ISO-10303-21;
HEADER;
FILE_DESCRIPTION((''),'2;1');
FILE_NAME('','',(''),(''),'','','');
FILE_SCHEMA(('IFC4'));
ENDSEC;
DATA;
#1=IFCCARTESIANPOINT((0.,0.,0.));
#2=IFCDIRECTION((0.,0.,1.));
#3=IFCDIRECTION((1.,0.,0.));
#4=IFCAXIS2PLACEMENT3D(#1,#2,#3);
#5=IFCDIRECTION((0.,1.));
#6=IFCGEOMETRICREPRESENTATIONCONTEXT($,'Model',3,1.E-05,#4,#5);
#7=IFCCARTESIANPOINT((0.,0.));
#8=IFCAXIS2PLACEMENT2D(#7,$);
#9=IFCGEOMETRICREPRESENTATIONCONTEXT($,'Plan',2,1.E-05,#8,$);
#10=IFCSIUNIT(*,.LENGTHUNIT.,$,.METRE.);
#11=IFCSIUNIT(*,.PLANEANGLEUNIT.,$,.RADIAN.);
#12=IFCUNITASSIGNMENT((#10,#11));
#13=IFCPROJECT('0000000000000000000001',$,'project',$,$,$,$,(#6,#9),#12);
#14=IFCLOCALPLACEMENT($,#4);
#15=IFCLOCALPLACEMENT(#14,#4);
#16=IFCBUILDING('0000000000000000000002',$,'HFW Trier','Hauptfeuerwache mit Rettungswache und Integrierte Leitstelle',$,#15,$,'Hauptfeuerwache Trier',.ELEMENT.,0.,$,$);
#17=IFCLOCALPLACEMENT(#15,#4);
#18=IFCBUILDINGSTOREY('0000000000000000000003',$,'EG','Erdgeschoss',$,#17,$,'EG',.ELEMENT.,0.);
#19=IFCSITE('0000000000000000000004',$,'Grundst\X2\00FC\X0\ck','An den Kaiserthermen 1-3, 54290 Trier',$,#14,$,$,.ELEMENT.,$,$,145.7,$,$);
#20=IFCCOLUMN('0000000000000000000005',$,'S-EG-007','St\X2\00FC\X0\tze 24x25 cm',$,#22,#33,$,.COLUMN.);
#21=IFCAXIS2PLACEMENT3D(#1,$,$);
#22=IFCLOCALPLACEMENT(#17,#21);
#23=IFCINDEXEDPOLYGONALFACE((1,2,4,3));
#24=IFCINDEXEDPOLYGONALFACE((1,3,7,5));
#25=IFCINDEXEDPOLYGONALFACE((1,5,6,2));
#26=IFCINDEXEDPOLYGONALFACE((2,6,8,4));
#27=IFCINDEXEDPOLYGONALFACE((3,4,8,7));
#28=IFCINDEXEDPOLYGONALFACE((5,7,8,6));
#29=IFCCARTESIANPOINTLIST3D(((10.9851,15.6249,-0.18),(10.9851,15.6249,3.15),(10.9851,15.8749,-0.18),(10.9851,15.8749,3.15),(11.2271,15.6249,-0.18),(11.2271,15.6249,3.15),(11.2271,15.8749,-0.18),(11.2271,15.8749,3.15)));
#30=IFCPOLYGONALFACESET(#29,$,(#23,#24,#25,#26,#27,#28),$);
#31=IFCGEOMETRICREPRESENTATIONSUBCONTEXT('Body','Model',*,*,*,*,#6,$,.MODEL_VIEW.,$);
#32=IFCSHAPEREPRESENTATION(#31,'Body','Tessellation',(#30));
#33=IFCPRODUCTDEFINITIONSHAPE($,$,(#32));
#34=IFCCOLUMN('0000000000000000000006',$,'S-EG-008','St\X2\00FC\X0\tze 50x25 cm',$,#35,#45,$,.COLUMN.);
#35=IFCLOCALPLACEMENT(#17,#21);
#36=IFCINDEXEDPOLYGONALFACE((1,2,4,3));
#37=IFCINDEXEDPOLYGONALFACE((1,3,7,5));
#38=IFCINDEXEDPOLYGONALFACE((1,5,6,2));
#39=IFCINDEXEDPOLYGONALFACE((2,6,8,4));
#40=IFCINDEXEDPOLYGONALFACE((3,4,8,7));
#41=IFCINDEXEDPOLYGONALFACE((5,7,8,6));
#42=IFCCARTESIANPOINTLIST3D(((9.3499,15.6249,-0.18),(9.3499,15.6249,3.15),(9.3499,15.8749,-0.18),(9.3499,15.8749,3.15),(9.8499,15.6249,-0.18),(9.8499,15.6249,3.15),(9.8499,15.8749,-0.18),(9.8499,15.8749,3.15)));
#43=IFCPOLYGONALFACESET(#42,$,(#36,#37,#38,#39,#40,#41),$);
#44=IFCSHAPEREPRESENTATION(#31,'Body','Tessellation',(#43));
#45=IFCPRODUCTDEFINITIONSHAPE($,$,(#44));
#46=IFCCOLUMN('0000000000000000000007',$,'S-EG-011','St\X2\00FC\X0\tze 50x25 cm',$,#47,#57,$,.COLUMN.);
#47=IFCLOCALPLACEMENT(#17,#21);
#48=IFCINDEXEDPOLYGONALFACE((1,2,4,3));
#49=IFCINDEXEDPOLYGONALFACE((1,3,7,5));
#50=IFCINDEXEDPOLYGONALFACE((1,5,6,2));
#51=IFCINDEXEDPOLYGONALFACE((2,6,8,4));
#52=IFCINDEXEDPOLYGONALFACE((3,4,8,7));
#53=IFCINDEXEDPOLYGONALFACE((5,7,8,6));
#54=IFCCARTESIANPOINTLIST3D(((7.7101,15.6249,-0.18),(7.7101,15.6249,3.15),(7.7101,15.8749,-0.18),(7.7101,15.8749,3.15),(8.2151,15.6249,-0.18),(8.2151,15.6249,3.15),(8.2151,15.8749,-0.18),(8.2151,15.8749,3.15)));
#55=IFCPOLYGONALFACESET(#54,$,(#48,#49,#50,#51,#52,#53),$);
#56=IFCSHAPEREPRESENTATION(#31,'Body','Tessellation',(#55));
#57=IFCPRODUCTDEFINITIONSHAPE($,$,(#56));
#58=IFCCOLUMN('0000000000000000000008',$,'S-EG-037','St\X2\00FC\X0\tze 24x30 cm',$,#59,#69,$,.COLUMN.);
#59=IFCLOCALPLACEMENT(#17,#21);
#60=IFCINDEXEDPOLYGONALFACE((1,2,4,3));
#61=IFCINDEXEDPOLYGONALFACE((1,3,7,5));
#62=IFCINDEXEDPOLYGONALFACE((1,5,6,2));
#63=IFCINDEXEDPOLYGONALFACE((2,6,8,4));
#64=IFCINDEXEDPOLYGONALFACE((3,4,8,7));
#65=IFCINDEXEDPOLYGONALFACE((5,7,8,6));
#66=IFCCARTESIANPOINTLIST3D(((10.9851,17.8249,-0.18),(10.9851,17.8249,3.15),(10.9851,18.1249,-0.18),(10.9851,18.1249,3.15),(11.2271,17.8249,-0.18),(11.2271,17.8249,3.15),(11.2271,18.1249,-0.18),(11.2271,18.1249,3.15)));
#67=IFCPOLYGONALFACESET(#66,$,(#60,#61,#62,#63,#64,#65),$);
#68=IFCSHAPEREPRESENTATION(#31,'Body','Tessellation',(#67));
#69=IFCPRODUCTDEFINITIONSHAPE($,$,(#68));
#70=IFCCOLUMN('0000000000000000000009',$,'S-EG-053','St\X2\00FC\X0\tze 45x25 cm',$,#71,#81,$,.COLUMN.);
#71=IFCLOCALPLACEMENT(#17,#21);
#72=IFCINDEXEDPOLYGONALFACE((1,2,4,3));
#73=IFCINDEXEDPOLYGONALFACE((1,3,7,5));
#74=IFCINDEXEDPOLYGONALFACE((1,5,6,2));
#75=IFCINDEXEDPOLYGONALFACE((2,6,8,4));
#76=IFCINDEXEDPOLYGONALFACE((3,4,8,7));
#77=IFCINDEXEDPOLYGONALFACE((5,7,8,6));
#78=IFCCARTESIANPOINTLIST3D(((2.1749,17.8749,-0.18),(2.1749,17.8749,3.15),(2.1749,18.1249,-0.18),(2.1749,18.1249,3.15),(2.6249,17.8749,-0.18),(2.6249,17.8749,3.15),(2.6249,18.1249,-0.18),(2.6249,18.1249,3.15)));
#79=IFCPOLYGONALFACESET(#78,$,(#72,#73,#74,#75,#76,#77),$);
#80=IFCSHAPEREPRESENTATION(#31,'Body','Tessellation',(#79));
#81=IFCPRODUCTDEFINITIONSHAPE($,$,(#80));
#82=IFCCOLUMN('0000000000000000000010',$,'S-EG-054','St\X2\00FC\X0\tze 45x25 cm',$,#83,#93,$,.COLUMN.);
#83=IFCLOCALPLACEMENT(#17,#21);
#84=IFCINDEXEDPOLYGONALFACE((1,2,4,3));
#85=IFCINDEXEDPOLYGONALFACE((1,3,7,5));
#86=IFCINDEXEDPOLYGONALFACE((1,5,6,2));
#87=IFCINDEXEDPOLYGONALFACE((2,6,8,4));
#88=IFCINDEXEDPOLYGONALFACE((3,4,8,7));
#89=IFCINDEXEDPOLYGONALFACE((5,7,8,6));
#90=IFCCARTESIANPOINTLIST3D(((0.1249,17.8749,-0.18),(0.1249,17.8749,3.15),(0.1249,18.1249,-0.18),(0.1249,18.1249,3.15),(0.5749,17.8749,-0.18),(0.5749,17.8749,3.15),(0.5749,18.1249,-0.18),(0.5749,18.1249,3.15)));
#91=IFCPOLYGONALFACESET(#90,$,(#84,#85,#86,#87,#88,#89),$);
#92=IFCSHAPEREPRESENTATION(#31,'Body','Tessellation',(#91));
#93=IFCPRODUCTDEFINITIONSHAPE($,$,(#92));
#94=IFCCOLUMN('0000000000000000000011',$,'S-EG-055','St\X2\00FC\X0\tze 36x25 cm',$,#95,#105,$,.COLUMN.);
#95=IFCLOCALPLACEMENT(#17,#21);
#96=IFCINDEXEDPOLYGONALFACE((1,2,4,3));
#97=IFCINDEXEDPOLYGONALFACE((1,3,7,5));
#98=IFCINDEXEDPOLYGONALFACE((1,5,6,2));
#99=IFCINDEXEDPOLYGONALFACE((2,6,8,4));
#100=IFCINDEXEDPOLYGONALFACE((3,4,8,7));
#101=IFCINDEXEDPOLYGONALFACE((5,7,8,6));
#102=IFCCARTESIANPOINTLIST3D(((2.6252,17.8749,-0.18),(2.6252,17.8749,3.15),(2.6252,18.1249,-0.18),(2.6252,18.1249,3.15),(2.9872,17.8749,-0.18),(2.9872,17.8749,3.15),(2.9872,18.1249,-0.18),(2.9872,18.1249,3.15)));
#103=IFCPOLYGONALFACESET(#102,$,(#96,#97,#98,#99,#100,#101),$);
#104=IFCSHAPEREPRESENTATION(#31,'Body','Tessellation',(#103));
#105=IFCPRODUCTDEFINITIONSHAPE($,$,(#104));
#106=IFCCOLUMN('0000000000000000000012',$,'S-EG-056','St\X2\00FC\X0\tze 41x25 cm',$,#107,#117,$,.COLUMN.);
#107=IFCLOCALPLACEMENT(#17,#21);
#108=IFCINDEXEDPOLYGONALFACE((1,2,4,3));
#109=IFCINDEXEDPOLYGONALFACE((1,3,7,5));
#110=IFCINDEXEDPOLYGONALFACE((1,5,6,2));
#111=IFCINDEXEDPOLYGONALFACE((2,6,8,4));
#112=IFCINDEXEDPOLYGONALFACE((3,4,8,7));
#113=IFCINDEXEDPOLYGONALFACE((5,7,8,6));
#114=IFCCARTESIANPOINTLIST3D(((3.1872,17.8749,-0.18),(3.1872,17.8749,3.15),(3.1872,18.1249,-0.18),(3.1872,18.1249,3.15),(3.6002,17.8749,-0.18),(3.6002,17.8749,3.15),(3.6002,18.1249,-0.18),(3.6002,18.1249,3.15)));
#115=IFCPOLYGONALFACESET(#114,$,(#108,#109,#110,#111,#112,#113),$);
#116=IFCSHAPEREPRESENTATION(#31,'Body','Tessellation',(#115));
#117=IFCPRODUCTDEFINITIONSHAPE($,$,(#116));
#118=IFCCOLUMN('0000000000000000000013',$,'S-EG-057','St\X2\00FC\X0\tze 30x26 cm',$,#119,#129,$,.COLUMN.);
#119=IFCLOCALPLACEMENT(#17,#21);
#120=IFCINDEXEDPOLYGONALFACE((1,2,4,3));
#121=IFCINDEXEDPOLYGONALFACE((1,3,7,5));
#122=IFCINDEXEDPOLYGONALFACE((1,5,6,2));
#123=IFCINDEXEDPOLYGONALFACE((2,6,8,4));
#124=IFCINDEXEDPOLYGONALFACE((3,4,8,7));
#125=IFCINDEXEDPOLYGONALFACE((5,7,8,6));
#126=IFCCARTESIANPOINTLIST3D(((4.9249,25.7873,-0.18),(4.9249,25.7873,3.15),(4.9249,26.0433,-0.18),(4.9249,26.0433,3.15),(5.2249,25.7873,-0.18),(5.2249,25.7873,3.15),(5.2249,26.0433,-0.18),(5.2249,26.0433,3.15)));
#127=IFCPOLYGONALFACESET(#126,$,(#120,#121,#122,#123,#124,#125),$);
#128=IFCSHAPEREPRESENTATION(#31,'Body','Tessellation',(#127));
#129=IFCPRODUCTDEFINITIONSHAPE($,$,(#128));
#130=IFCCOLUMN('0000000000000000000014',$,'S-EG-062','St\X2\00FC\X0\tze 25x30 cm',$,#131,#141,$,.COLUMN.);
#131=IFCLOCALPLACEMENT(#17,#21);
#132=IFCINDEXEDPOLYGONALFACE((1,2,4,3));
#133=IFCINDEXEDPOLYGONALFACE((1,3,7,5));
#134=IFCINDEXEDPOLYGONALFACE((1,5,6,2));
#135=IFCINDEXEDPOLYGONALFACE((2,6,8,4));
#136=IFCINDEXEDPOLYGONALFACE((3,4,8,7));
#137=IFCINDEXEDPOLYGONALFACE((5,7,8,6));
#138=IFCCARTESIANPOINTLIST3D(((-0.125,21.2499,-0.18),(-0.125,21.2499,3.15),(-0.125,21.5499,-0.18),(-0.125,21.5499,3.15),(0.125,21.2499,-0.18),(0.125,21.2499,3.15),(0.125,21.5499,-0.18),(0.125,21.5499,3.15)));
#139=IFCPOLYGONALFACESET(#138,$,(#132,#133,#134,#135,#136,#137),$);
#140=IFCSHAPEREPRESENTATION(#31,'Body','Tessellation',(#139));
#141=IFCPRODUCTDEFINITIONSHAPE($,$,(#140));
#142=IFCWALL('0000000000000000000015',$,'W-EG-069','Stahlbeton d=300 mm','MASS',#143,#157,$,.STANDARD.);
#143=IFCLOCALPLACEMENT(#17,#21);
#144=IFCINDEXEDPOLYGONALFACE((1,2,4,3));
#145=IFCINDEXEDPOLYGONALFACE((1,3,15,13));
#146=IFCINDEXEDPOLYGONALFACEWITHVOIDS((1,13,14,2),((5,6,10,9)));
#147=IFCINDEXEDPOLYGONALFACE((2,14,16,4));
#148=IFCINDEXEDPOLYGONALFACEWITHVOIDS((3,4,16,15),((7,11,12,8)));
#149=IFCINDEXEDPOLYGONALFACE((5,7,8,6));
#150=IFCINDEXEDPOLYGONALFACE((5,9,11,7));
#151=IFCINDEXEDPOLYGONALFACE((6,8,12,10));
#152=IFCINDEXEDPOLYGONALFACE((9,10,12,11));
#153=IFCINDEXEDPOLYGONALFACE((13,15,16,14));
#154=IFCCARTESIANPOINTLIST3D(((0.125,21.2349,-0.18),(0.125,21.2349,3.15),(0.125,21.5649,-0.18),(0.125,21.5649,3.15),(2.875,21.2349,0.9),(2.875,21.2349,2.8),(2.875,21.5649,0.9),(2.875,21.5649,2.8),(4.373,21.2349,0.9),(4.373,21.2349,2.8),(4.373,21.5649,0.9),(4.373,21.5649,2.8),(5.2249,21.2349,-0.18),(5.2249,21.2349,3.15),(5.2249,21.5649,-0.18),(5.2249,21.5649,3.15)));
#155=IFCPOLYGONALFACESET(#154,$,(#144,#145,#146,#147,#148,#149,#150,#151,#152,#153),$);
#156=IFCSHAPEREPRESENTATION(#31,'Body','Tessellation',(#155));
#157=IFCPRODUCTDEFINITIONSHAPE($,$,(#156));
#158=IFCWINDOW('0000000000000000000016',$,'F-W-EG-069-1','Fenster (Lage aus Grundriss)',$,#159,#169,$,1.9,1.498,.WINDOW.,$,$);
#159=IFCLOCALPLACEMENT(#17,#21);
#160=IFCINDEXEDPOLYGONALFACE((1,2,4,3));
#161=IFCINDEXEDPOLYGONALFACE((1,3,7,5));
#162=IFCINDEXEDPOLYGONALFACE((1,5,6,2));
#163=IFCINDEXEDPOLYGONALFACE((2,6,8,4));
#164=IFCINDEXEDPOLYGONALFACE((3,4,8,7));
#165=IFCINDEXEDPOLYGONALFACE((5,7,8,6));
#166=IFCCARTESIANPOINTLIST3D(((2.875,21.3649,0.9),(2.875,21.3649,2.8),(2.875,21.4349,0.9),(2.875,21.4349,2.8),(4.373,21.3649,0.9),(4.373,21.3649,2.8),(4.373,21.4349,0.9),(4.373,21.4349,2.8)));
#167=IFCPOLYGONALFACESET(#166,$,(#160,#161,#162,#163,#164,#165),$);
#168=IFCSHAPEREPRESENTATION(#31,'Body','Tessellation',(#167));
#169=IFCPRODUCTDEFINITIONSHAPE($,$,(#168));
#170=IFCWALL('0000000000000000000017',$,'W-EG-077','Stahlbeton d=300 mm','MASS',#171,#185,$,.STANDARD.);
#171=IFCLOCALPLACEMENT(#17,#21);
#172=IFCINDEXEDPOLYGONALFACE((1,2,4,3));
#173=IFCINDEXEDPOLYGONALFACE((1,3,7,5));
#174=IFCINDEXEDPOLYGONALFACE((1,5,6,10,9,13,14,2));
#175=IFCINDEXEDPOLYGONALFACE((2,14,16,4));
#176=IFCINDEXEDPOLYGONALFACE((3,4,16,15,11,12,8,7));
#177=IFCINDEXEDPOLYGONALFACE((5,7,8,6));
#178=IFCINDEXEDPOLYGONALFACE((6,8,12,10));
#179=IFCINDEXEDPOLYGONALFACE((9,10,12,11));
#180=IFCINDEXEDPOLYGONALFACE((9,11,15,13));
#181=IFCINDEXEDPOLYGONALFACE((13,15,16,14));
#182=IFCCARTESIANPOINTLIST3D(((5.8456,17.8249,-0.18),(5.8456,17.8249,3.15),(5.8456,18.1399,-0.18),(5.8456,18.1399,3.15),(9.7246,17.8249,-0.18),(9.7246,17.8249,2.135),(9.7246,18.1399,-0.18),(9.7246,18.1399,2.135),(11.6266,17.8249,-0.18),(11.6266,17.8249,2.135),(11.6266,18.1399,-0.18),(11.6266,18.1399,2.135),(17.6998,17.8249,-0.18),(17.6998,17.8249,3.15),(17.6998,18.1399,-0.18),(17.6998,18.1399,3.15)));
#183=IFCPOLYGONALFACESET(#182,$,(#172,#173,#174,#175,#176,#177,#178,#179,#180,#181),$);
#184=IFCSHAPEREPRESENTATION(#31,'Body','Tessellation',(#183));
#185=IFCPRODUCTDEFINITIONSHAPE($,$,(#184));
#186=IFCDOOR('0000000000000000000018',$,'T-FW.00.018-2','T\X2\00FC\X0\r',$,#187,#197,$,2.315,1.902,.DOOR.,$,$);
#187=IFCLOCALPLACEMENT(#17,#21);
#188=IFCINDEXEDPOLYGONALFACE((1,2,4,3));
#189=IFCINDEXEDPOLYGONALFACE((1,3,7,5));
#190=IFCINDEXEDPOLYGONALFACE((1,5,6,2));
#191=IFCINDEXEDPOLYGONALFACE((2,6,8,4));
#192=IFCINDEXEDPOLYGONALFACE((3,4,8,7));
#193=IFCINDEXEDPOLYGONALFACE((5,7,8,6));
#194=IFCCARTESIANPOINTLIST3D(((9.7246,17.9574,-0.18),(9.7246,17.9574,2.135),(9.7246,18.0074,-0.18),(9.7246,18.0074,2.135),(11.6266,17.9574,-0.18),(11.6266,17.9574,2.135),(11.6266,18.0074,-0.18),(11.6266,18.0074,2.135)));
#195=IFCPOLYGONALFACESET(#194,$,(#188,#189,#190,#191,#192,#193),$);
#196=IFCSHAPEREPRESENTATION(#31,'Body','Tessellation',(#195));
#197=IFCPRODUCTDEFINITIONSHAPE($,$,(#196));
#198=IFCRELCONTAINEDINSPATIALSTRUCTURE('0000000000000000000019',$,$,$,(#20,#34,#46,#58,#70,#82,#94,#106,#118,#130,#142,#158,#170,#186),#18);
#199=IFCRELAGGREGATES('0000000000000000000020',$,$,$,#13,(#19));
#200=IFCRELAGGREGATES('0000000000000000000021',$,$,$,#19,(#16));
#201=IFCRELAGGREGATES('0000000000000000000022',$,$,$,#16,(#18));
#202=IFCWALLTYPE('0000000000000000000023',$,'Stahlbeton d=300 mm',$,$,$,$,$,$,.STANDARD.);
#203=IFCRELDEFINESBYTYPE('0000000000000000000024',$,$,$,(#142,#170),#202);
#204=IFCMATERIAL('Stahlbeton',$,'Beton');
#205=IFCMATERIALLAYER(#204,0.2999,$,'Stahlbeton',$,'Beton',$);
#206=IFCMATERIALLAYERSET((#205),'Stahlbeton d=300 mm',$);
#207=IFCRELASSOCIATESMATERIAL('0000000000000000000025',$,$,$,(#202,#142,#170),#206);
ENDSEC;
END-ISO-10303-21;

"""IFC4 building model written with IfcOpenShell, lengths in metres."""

from ifc_helpers import new_model, si_unit, direction, frame, frame_2d, origin_with_axes, origin_2d, place, context, subcontext, project, spatial, rectangle, extrude, material, layer, layer_set, layer_usage, type_object, element, fill, save


model = new_model("IFC4")

# Units and contexts
model_context = context("Model", 3, precision=1e-05, world=origin_with_axes(), true_north=direction((0.0, 1.0)))
plan_context = context("Plan", 2, precision=1e-05, world=origin_2d())
body_context = subcontext(model_context, "Body", "Model", "MODEL_VIEW")
ifc_project = project(units=[si_unit("LENGTHUNIT", "METRE"), si_unit("PLANEANGLEUNIT", "RADIAN")], contexts=[model_context, plan_context])

# Site, building, storey
site_placement = place(None, origin_with_axes())
site = spatial("IfcSite", under=ifc_project, at=site_placement, Name="Grundstück", Description="An den Kaiserthermen 1-3, 54290 Trier", CompositionType="ELEMENT", RefElevation=145.7)
building_placement = place(site_placement, origin_with_axes())
building = spatial("IfcBuilding", under=site, at=building_placement, Name="HFW Trier", Description="Hauptfeuerwache mit Rettungswache und Integrierte Leitstelle", LongName="Hauptfeuerwache Trier", CompositionType="ELEMENT", ElevationOfRefHeight=0.0)
storey_placement = place(building_placement, origin_with_axes())
storey = spatial("IfcBuildingStorey", under=building, at=storey_placement, Name="EG", Description="Erdgeschoss", LongName="EG", CompositionType="ELEMENT", Elevation=0.0)

# Columns
column_1_placement = place(storey_placement, frame((10.9851, 15.7499, -0.18), z_axis=(0.0, 0.0, 1.0), x_axis=(1.0, 0.0, 0.0)))
element("IfcColumn", 1, at=column_1_placement, inside=storey, Name="S-EG-007", Description="Stütze 24x25 cm", PredefinedType="COLUMN", context=body_context, shape_type="SweptSolid", body=[
    extrude(rectangle(XDim=0.242, YDim=0.25, at=frame_2d((0.121, 0.0))), origin_with_axes(), (0.0, 0.0, 1.0), 3.33),
])
column_2_placement = place(storey_placement, frame((9.3499, 15.7499, -0.18), z_axis=(0.0, 0.0, 1.0), x_axis=(1.0, 0.0, 0.0)))
element("IfcColumn", 2, at=column_2_placement, inside=storey, Name="S-EG-008", Description="Stütze 50x25 cm", PredefinedType="COLUMN", context=body_context, shape_type="SweptSolid", body=[
    extrude(rectangle(XDim=0.5, YDim=0.25, at=frame_2d((0.25, 0.0))), origin_with_axes(), (0.0, 0.0, 1.0), 3.33),
])
column_3_placement = place(storey_placement, frame((7.7101, 15.7499, -0.18), z_axis=(0.0, 0.0, 1.0), x_axis=(1.0, 0.0, 0.0)))
element("IfcColumn", 3, at=column_3_placement, inside=storey, Name="S-EG-011", Description="Stütze 50x25 cm", PredefinedType="COLUMN", context=body_context, shape_type="SweptSolid", body=[
    extrude(rectangle(XDim=0.505, YDim=0.25, at=frame_2d((0.2525, 0.0))), origin_with_axes(), (0.0, 0.0, 1.0), 3.33),
])
column_4_placement = place(storey_placement, frame((10.9851, 17.9749, -0.18), z_axis=(0.0, 0.0, 1.0), x_axis=(1.0, 0.0, 0.0)))
element("IfcColumn", 4, at=column_4_placement, inside=storey, Name="S-EG-037", Description="Stütze 24x30 cm", PredefinedType="COLUMN", context=body_context, shape_type="SweptSolid", body=[
    extrude(rectangle(XDim=0.242, YDim=0.3, at=frame_2d((0.121, 0.0))), origin_with_axes(), (0.0, 0.0, 1.0), 3.33),
])
for number, where, z_axis, x_axis, name in (
    (5, (2.1749, 17.9999, -0.18), (0.0, 0.0, 1.0), (1.0, 0.0, 0.0), "S-EG-053"),
    (6, (0.1249, 17.9999, -0.18), (0.0, 0.0, 1.0), (1.0, 0.0, 0.0), "S-EG-054"),
):
    element("IfcColumn", number, at=place(storey_placement, frame(where, z_axis=z_axis, x_axis=x_axis)), inside=storey, Name=name, Description="Stütze 45x25 cm", PredefinedType="COLUMN", context=body_context, shape_type="SweptSolid", body=[
        extrude(rectangle(XDim=0.45, YDim=0.25, at=frame_2d((0.225, 0.0))), origin_with_axes(), (0.0, 0.0, 1.0), 3.33),
    ])
column_5_placement = place(storey_placement, frame((2.6252, 17.9999, -0.18), z_axis=(0.0, 0.0, 1.0), x_axis=(1.0, 0.0, 0.0)))
element("IfcColumn", 7, at=column_5_placement, inside=storey, Name="S-EG-055", Description="Stütze 36x25 cm", PredefinedType="COLUMN", context=body_context, shape_type="SweptSolid", body=[
    extrude(rectangle(XDim=0.362, YDim=0.25, at=frame_2d((0.181, 0.0))), origin_with_axes(), (0.0, 0.0, 1.0), 3.33),
])
column_6_placement = place(storey_placement, frame((3.1872, 17.9999, -0.18), z_axis=(0.0, 0.0, 1.0), x_axis=(1.0, 0.0, 0.0)))
element("IfcColumn", 8, at=column_6_placement, inside=storey, Name="S-EG-056", Description="Stütze 41x25 cm", PredefinedType="COLUMN", context=body_context, shape_type="SweptSolid", body=[
    extrude(rectangle(XDim=0.413, YDim=0.25, at=frame_2d((0.2065, 0.0))), origin_with_axes(), (0.0, 0.0, 1.0), 3.33),
])
column_7_placement = place(storey_placement, frame((4.9249, 25.9153, -0.18), z_axis=(0.0, 0.0, 1.0), x_axis=(1.0, 0.0, 0.0)))
element("IfcColumn", 9, at=column_7_placement, inside=storey, Name="S-EG-057", Description="Stütze 30x26 cm", PredefinedType="COLUMN", context=body_context, shape_type="SweptSolid", body=[
    extrude(rectangle(XDim=0.3, YDim=0.256, at=frame_2d((0.15, 0.0))), origin_with_axes(), (0.0, 0.0, 1.0), 3.33),
])
column_8_placement = place(storey_placement, frame((-0.125, 21.3999, -0.18), z_axis=(0.0, 0.0, 1.0), x_axis=(1.0, 0.0, 0.0)))
element("IfcColumn", 10, at=column_8_placement, inside=storey, Name="S-EG-062", Description="Stütze 25x30 cm", PredefinedType="COLUMN", context=body_context, shape_type="SweptSolid", body=[
    extrude(rectangle(XDim=0.25, YDim=0.3, at=frame_2d((0.125, 0.0))), origin_with_axes(), (0.0, 0.0, 1.0), 3.33),
])

# Wall, opening, window
ifc_material_1 = material(Name="Stahlbeton", Category="Beton")
ifc_layer_1 = layer(ifc_material_1, 0.2999, Name="Stahlbeton", Category="Beton")
ifc_layer_set_1 = layer_set([ifc_layer_1], Name="Stahlbeton d=300 mm")
ifc_layer_usage_1 = layer_usage(ifc_layer_set_1, "AXIS2", "POSITIVE", -0.165)
wall_type_1 = type_object("IfcWallType", Name="Stahlbeton d=300 mm", PredefinedType="STANDARD", material=ifc_layer_set_1)
wall_1_placement = place(storey_placement, frame((0.125, 21.3999, -0.18), z_axis=(0.0, 0.0, 1.0), x_axis=(1.0, 0.0, 0.0)))
wall_1 = element("IfcWall", 11, at=wall_1_placement, inside=storey, type_object=wall_type_1, material=ifc_layer_usage_1, Name="W-EG-069", Description="Stahlbeton d=300 mm", ObjectType="MASS", PredefinedType="STANDARD", context=body_context, shape_type="SweptSolid", body=[
    extrude(rectangle(XDim=5.0999, YDim=0.33, at=frame_2d((2.5499, 0.0))), origin_with_axes(), (0.0, 0.0, 1.0), 3.33),
])
opening_1_placement = place(wall_1_placement, frame((2.75, 0.0, 0.0), z_axis=(0.0, 0.0, 1.0), x_axis=(1.0, 0.0, 0.0)))
opening_1 = element("IfcOpeningElement", 12, at=opening_1_placement, cuts=wall_1, PredefinedType="OPENING", context=body_context, shape_type="SweptSolid", body=[
    extrude(rectangle(XDim=1.498, YDim=0.43, at=frame_2d((0.749, 0.0))), frame((0.0, 0.0, 1.08), z_axis=(0.0, 0.0, 1.0), x_axis=(1.0, 0.0, 0.0)), (0.0, 0.0, 1.0), 1.9),
])
window_placement = place(wall_1_placement, frame((2.75, 0.0, 0.0), z_axis=(0.0, 0.0, 1.0), x_axis=(1.0, 0.0, 0.0)))
window = element("IfcWindow", 13, at=window_placement, inside=storey, Name="F-W-EG-069-1", Description="Fenster (Lage aus Grundriss)", OverallHeight=1.9, OverallWidth=1.498, PredefinedType="WINDOW", context=body_context, shape_type="SweptSolid", body=[
    extrude(rectangle(XDim=1.498, YDim=0.07, at=frame_2d((0.749, 0.0))), frame((0.0, 0.0, 1.08), z_axis=(0.0, 0.0, 1.0), x_axis=(1.0, 0.0, 0.0)), (0.0, 0.0, 1.0), 1.9),
])
fill(opening_1, window)

# Wall, opening, door
ifc_layer_usage_2 = layer_usage(ifc_layer_set_1, "AXIS2", "POSITIVE", -0.1575)
wall_2_placement = place(storey_placement, frame((5.8456, 17.9824, -0.18), z_axis=(0.0, 0.0, 1.0), x_axis=(1.0, 0.0, 0.0)))
wall_2 = element("IfcWall", 14, at=wall_2_placement, inside=storey, type_object=wall_type_1, material=ifc_layer_usage_2, Name="W-EG-077", Description="Stahlbeton d=300 mm", ObjectType="MASS", PredefinedType="STANDARD", context=body_context, shape_type="SweptSolid", body=[
    extrude(rectangle(XDim=11.8542, YDim=0.315, at=frame_2d((5.9271, 0.0))), origin_with_axes(), (0.0, 0.0, 1.0), 3.33),
])
opening_2_placement = place(wall_2_placement, frame((3.879, 0.0, 0.0), z_axis=(0.0, 0.0, 1.0), x_axis=(1.0, 0.0, 0.0)))
opening_2 = element("IfcOpeningElement", 15, at=opening_2_placement, cuts=wall_2, PredefinedType="OPENING", context=body_context, shape_type="SweptSolid", body=[
    extrude(rectangle(XDim=1.902, YDim=0.415, at=frame_2d((0.951, 0.0))), origin_with_axes(), (0.0, 0.0, 1.0), 2.315),
])
door_placement = place(wall_2_placement, frame((3.879, 0.0, 0.0), z_axis=(0.0, 0.0, 1.0), x_axis=(1.0, 0.0, 0.0)))
door = element("IfcDoor", 16, at=door_placement, inside=storey, Name="T-FW.00.018-2", Description="Tür", OverallHeight=2.315, OverallWidth=1.902, PredefinedType="DOOR", context=body_context, shape_type="SweptSolid", body=[
    extrude(rectangle(XDim=1.902, YDim=0.05, at=frame_2d((0.951, 0.0))), origin_with_axes(), (0.0, 0.0, 1.0), 2.315),
])
fill(opening_2, door)

save(model, "model.ifc")
